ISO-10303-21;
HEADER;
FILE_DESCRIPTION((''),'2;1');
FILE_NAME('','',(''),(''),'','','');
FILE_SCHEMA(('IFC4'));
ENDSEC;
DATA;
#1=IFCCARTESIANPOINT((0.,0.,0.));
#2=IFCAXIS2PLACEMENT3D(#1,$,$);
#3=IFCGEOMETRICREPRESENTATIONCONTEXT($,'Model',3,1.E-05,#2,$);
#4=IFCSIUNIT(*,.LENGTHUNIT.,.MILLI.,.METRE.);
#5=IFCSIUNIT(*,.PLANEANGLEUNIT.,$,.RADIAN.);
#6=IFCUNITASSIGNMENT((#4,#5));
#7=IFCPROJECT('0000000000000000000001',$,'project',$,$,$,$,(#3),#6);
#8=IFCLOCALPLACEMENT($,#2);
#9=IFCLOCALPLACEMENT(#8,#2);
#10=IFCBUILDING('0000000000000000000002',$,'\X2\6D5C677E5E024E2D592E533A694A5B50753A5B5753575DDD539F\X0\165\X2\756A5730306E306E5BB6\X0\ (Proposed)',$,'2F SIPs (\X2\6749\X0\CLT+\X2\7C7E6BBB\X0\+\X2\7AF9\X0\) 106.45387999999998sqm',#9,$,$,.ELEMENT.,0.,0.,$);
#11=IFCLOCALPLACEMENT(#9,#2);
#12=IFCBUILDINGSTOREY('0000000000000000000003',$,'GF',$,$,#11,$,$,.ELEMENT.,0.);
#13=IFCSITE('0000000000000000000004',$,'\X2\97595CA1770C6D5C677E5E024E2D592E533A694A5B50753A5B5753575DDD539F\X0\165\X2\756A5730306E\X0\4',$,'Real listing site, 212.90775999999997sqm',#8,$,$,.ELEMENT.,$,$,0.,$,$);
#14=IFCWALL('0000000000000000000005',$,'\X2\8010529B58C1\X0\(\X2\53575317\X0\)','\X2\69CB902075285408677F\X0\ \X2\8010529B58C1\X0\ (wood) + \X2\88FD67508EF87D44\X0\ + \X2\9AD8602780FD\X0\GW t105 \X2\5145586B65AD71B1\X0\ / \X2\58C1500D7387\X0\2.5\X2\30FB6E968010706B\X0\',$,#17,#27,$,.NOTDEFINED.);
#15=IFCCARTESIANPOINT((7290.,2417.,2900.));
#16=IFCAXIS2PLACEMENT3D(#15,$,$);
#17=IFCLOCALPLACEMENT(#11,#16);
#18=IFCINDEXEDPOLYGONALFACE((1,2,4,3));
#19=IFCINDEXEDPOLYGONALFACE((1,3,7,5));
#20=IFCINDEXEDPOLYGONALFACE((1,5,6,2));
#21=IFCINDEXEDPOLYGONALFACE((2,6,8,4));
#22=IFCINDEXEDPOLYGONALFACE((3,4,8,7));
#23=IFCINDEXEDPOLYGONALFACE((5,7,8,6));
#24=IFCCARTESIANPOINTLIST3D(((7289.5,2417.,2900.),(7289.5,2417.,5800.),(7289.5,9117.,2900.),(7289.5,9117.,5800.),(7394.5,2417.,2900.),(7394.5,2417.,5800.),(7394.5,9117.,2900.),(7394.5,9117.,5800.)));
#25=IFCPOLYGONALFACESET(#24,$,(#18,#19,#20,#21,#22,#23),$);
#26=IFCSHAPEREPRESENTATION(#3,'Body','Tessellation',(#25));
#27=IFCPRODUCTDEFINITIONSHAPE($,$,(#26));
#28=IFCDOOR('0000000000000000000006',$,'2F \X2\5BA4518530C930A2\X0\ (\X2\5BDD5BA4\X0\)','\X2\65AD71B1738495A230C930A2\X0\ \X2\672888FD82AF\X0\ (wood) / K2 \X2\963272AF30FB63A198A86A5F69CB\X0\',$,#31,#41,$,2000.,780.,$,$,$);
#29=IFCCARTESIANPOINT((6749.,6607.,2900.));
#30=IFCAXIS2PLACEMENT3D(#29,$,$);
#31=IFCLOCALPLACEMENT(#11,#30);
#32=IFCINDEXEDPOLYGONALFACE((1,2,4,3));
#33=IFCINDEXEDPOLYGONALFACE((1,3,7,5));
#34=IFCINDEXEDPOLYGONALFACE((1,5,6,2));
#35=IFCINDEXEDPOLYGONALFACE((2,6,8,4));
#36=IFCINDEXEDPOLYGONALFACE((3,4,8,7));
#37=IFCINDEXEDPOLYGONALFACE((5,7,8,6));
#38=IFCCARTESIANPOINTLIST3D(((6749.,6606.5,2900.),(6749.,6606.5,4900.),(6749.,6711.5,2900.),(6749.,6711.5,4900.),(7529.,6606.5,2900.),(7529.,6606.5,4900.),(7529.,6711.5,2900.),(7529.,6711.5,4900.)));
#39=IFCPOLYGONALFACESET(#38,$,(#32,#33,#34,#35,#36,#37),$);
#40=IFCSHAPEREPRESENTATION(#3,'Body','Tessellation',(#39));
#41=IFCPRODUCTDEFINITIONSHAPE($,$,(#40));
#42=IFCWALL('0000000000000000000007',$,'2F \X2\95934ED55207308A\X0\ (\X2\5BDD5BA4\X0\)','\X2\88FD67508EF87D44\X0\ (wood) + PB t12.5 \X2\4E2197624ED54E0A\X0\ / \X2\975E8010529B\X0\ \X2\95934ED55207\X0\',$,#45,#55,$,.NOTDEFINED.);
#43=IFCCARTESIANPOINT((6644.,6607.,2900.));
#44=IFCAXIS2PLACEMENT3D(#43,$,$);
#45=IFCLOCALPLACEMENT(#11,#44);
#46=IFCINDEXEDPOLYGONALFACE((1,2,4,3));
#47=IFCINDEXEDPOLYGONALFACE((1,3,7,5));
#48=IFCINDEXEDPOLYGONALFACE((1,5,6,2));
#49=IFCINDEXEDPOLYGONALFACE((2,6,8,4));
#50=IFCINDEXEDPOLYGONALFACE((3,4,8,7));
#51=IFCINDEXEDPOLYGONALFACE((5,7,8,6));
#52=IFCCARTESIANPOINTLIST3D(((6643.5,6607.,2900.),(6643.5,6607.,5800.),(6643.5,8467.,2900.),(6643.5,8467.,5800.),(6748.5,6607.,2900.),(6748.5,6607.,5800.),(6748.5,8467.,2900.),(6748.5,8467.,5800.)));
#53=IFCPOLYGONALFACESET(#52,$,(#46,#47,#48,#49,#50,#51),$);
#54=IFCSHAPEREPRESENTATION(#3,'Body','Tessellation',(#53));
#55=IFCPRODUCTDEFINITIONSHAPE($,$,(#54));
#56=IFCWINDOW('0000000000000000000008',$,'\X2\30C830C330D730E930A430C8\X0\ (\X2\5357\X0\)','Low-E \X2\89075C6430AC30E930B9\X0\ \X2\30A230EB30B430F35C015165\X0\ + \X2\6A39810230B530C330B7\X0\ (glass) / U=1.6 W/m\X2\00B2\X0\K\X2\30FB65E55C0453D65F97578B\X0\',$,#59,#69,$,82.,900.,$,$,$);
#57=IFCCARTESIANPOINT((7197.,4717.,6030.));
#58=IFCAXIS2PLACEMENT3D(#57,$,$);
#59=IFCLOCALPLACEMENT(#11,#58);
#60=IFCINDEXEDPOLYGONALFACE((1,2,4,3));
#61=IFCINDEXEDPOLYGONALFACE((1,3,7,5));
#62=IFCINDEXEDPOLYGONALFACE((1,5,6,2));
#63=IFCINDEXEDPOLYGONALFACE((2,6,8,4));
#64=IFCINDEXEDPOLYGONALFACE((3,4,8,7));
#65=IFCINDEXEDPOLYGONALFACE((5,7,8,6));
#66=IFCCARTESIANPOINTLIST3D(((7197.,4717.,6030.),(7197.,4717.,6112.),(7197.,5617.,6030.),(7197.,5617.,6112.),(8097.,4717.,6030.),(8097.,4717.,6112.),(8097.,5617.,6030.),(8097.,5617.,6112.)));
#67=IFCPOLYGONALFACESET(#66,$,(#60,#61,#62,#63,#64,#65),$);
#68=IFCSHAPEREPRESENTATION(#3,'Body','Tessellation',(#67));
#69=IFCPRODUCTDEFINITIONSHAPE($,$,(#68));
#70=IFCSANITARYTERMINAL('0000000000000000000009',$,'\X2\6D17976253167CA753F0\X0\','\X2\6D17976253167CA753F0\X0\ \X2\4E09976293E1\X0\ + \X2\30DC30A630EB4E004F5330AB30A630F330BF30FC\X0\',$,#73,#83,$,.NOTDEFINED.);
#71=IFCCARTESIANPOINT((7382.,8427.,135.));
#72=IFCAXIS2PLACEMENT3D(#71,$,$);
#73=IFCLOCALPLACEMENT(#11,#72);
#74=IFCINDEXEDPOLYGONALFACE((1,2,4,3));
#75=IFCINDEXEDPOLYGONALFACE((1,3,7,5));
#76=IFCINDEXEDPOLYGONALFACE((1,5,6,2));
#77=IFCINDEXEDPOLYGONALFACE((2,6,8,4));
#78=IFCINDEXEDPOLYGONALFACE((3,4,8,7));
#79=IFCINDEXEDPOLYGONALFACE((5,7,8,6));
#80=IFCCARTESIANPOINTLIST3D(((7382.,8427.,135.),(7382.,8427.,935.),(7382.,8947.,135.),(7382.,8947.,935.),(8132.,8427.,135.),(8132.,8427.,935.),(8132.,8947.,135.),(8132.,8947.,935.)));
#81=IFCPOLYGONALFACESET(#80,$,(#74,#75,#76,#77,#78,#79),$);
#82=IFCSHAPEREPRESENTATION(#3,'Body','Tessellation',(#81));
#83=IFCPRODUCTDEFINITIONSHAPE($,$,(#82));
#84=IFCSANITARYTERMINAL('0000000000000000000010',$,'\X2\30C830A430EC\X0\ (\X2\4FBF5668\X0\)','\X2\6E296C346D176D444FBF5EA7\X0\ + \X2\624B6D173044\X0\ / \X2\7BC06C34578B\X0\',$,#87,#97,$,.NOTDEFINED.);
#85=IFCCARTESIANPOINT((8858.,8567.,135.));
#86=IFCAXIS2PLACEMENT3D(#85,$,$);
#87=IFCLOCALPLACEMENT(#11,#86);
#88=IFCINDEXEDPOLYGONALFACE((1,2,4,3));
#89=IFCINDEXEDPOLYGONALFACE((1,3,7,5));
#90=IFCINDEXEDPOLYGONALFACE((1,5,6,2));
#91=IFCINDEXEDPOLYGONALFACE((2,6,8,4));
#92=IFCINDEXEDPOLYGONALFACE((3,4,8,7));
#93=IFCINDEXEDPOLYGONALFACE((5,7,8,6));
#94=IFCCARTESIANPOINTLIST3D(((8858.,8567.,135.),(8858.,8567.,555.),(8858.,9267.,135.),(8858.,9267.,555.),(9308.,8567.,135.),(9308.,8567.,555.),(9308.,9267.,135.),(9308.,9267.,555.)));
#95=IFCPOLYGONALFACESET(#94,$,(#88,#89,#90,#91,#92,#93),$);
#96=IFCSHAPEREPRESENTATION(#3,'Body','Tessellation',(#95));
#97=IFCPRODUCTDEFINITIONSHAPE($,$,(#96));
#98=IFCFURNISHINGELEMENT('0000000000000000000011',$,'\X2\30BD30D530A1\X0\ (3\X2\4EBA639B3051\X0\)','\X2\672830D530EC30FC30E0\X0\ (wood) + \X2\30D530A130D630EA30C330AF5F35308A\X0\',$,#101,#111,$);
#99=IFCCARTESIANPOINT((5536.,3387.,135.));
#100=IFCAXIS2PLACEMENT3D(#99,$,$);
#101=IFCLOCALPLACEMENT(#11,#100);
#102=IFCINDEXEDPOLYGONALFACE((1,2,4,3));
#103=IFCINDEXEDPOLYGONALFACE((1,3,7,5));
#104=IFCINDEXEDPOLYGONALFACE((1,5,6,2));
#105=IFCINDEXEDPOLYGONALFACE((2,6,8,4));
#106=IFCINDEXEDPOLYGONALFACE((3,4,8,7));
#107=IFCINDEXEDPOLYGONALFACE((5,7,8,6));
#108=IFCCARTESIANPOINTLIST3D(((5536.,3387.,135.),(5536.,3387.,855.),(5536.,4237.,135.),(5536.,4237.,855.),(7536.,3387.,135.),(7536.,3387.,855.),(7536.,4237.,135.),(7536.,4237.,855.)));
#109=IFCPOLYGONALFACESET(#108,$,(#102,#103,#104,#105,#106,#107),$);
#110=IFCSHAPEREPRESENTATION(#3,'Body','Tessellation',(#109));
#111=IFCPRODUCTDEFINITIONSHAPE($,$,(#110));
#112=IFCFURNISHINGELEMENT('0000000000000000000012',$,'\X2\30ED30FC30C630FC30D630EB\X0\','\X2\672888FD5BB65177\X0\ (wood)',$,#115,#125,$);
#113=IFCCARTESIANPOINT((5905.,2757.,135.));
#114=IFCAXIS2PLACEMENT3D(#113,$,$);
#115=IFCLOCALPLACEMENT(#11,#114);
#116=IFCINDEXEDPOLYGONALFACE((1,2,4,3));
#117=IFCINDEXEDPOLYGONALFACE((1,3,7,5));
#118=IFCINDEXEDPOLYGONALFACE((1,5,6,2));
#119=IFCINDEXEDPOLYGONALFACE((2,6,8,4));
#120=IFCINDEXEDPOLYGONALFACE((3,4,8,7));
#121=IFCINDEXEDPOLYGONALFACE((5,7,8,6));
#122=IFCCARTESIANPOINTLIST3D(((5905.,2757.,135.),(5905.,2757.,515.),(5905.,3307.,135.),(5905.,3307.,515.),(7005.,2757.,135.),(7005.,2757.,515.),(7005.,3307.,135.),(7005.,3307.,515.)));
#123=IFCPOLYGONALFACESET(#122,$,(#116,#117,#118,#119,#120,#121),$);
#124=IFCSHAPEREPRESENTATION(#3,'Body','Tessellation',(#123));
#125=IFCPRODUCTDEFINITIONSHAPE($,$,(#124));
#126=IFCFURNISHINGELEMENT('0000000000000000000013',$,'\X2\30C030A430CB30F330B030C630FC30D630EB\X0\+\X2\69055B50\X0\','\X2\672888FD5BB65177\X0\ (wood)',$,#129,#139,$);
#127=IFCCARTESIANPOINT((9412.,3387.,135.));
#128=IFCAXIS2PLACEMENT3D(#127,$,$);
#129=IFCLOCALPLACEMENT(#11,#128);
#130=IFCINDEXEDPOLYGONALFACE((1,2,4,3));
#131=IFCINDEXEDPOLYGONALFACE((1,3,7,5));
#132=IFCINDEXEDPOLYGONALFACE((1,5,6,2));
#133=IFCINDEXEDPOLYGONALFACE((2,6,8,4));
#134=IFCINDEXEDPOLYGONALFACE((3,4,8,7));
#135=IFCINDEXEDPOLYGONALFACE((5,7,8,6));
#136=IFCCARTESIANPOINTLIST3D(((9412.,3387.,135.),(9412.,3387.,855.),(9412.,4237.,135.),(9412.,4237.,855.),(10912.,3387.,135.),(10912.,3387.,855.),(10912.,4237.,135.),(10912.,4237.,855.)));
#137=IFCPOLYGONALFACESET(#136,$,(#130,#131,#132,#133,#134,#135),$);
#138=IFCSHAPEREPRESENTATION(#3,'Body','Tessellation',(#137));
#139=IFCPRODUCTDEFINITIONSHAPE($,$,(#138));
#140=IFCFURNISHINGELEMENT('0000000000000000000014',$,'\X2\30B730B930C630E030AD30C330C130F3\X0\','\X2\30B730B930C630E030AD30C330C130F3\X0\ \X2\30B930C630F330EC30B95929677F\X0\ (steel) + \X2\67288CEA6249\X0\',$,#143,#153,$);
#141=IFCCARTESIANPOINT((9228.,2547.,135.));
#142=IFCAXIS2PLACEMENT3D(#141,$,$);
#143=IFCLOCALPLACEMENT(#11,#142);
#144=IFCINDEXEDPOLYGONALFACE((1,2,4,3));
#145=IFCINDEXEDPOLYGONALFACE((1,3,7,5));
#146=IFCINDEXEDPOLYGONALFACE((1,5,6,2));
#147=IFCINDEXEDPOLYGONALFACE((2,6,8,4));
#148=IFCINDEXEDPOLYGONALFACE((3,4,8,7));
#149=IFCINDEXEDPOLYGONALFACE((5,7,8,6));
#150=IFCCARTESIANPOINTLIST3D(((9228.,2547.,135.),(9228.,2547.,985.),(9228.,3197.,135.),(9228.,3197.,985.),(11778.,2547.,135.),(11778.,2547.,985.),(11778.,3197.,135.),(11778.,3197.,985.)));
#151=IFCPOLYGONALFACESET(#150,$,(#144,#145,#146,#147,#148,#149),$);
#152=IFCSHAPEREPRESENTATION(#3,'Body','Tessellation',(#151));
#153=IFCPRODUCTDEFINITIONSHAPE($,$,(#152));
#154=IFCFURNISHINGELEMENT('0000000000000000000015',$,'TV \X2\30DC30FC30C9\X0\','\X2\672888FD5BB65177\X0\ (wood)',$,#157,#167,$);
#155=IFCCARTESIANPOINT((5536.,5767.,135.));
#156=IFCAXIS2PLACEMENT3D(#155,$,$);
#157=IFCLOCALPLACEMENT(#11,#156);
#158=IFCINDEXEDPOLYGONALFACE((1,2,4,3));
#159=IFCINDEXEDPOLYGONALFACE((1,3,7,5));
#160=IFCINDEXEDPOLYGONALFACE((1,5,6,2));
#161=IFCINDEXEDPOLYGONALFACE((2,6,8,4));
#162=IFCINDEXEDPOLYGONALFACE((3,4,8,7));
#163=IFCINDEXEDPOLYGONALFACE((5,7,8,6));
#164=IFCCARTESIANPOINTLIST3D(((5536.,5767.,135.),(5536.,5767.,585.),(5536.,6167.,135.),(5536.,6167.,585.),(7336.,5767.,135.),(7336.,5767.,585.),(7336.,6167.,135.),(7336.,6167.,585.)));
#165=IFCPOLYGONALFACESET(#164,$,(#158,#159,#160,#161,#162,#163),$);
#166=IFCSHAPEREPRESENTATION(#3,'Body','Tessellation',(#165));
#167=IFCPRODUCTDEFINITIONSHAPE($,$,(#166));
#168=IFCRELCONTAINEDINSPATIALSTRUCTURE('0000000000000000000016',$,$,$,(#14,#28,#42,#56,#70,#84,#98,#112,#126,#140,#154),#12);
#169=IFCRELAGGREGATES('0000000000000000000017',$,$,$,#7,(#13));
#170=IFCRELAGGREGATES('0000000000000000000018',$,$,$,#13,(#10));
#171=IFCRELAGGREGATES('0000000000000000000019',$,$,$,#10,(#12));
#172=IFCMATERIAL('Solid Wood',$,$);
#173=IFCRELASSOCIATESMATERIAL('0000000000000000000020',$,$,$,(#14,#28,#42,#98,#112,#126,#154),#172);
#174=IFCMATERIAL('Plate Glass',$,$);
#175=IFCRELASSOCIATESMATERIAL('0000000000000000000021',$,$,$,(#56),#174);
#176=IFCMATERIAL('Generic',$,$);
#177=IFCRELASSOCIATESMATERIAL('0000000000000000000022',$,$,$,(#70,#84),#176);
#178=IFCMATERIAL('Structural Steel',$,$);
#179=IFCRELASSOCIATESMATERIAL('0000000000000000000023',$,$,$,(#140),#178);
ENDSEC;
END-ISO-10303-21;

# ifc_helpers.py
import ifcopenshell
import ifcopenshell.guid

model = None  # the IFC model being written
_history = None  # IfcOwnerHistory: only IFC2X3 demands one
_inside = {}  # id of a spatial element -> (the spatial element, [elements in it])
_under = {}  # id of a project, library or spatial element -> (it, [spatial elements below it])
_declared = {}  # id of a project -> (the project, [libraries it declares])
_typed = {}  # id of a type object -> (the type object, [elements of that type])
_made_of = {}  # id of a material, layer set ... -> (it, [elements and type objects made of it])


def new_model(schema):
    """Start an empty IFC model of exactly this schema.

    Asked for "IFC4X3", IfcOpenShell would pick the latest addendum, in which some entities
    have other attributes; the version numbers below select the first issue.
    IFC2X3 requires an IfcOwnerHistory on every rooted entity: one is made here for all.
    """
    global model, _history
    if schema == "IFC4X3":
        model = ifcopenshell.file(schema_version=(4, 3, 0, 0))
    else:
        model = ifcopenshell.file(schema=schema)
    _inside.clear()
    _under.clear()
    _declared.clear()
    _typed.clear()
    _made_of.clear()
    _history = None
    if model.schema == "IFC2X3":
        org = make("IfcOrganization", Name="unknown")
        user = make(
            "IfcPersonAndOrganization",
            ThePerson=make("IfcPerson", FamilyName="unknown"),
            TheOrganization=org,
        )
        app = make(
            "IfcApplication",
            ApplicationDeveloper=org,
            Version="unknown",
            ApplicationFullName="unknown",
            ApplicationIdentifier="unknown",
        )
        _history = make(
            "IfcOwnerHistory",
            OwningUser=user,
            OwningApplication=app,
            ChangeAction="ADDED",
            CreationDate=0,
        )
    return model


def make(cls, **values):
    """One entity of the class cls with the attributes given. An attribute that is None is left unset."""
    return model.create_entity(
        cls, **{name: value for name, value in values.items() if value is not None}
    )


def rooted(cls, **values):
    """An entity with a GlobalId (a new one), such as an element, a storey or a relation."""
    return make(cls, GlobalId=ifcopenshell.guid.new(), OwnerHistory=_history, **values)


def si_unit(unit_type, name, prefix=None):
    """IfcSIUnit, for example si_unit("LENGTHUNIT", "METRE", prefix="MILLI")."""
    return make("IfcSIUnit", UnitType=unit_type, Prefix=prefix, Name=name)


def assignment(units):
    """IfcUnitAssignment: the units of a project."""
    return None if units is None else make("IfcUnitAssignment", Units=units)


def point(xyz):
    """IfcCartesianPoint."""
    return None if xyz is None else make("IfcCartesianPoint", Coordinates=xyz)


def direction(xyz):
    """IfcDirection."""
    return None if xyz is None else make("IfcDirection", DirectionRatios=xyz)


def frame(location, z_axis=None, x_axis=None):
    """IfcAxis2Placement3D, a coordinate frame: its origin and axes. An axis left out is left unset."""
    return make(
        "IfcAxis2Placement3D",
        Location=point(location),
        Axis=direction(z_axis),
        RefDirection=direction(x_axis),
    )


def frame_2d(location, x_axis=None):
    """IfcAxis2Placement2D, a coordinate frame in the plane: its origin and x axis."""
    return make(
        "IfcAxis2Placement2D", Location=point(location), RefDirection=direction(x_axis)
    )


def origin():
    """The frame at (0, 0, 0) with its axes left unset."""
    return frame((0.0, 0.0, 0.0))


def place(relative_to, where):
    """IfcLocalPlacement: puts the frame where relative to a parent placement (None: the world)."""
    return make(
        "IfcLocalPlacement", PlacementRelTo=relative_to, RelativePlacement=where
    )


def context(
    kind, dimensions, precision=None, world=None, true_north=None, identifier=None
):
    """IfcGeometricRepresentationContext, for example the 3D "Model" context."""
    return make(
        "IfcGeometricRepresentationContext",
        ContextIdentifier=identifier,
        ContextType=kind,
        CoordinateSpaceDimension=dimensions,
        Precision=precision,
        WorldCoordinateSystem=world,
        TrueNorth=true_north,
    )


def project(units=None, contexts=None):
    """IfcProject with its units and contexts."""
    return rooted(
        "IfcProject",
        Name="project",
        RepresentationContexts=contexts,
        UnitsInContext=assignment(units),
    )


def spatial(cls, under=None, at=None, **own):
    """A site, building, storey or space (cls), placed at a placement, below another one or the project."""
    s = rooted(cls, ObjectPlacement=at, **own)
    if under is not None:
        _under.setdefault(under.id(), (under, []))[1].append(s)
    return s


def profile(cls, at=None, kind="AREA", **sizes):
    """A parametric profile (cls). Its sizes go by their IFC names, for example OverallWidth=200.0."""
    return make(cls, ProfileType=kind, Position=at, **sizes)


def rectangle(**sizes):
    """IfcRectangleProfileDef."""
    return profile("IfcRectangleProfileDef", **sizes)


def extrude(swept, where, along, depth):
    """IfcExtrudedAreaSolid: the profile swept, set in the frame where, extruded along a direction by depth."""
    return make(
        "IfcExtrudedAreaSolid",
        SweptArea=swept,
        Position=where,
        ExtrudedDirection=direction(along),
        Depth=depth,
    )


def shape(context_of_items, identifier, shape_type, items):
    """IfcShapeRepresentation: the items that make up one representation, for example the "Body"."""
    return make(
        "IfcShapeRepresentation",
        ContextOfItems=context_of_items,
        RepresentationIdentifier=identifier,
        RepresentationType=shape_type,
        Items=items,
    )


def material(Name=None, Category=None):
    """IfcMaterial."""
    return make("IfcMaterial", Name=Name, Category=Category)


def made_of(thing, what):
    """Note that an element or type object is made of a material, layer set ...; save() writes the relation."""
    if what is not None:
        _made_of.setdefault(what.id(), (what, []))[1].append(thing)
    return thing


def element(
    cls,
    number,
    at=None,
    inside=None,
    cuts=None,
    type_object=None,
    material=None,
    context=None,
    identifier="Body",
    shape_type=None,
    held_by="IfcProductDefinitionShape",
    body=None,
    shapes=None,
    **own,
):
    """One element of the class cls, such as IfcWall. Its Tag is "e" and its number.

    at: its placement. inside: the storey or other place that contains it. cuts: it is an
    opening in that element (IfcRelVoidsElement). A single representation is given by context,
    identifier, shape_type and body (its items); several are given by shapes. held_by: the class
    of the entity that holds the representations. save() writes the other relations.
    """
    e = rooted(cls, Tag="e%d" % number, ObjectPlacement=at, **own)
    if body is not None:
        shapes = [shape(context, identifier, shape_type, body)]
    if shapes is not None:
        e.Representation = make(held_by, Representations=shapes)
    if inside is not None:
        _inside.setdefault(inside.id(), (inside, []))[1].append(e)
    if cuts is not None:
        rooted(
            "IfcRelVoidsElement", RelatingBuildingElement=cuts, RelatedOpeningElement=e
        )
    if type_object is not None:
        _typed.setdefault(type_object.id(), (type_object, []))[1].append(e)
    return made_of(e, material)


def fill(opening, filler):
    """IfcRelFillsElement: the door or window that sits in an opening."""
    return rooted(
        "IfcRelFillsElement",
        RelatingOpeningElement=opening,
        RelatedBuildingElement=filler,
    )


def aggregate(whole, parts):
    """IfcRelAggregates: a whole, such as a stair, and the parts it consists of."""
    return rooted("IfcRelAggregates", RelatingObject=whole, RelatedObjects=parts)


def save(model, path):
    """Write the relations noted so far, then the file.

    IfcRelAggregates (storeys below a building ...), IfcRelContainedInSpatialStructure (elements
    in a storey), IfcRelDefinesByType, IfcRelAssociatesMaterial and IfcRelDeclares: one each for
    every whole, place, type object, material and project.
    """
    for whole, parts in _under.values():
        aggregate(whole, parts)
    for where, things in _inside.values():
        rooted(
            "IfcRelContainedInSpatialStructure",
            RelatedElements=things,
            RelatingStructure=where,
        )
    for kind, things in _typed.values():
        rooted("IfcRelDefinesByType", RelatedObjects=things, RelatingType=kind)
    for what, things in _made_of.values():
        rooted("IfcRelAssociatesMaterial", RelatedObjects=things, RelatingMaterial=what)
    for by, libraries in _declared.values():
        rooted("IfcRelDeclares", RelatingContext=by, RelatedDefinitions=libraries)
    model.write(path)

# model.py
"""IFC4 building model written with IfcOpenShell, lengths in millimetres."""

from ifc_helpers import new_model, si_unit, frame, frame_2d, origin, place, context, project, spatial, rectangle, extrude, material, element, fill, save


model = new_model("IFC4")

# Units and contexts
model_context = context("Model", 3, precision=1e-05, world=origin())
ifc_project = project(units=[si_unit("LENGTHUNIT", "METRE", prefix="MILLI"), si_unit("PLANEANGLEUNIT", "RADIAN")], contexts=[model_context])

# Site, building, storey
site_placement = place(None, origin())
site = spatial("IfcSite", under=ifc_project, at=site_placement, Name="静岡県浜松市中央区楊子町字南川原165番地の4", ObjectType="Real listing site, 212.90775999999997sqm", CompositionType="ELEMENT", RefElevation=0.0)
building_placement = place(site_placement, origin())
building = spatial("IfcBuilding", under=site, at=building_placement, Name="浜松市中央区楊子町字南川原165番地のの家 (Proposed)", ObjectType="2F SIPs (杉CLT+籾殻+竹) 106.45387999999998sqm", CompositionType="ELEMENT", ElevationOfRefHeight=0.0, ElevationOfTerrain=0.0)
storey_placement = place(building_placement, origin())
storey = spatial("IfcBuildingStorey", under=building, at=storey_placement, Name="GF", CompositionType="ELEMENT", Elevation=0.0)

# Shared definitions
ifc_material_1 = material(Name="Solid Wood")

# Wall, opening, door
wall_1_placement = place(storey_placement, frame((7290.0, 2417.0, 2900.0)))
wall_1 = element("IfcWall", 1, at=wall_1_placement, inside=storey, material=ifc_material_1, Name="耐力壁(南北)", Description="構造用合板 耐力壁 (wood) + 製材軸組 + 高性能GW t105 充填断熱 / 壁倍率2.5・準耐火", PredefinedType="NOTDEFINED", context=model_context, shape_type="SweptSolid", body=[
    extrude(rectangle(XDim=105.0, YDim=6700.0, at=frame_2d((52.0, 3350.0))), frame((7290.0, 2417.0, 2900.0)), (0.0, 0.0, 1.0), 2900.0),
])
opening_1_placement = place(storey_placement, frame((6749.0, 6607.0, 2900.0)))
opening_1 = element("IfcOpeningElement", 2, at=opening_1_placement, cuts=wall_1, PredefinedType="NOTDEFINED", context=model_context, shape_type="SweptSolid", body=[
    extrude(rectangle(XDim=780.0, YDim=105.0, at=frame_2d((390.0, 52.0))), frame((6749.0, 6607.0, 2900.0)), (0.0, 0.0, 1.0), 2000.0),
])
door_1_placement = place(storey_placement, frame((6749.0, 6607.0, 2900.0)))
door_1 = element("IfcDoor", 3, at=door_1_placement, inside=storey, material=ifc_material_1, Name="2F 室内ドア (寝室)", Description="断熱玄関ドア 木製芯 (wood) / K2 防犯・採風機構", OverallHeight=2000.0, OverallWidth=780.0, context=model_context, shape_type="SweptSolid", body=[
    extrude(rectangle(XDim=780.0, YDim=105.0, at=frame_2d((390.0, 52.0))), frame((6749.0, 6607.0, 2900.0)), (0.0, 0.0, 1.0), 2000.0),
])
fill(opening_1, door_1)

# Wall
wall_2_placement = place(storey_placement, frame((6644.0, 6607.0, 2900.0)))
element("IfcWall", 4, at=wall_2_placement, inside=storey, material=ifc_material_1, Name="2F 間仕切り (寝室)", Description="製材軸組 (wood) + PB t12.5 両面仕上 / 非耐力 間仕切", PredefinedType="NOTDEFINED", context=model_context, shape_type="SweptSolid", body=[
    extrude(rectangle(XDim=105.0, YDim=1860.0, at=frame_2d((52.0, 930.0))), frame((6644.0, 6607.0, 2900.0)), (0.0, 0.0, 1.0), 2900.0),
])

# Window
ifc_material_2 = material(Name="Plate Glass")
window_placement = place(storey_placement, frame((7197.0, 4717.0, 6030.0)))
element("IfcWindow", 5, at=window_placement, inside=storey, material=ifc_material_2, Name="トップライト (南)", Description="Low-E 複層ガラス アルゴン封入 + 樹脂サッシ (glass) / U=1.6 W/m²K・日射取得型", OverallHeight=82.0, OverallWidth=900.0, context=model_context, shape_type="SweptSolid", body=[
    extrude(rectangle(XDim=900.0, YDim=900.0, at=frame_2d((450.0, 450.0))), frame((7197.0, 4717.0, 6030.0)), (0.0, 0.0, 1.0), 82.0),
])

# Sanitary terminals
ifc_material_3 = material(Name="Generic")
sanitary_terminal_1_placement = place(storey_placement, frame((7382.0, 8427.0, 135.0)))
element("IfcSanitaryTerminal", 6, at=sanitary_terminal_1_placement, inside=storey, material=ifc_material_3, Name="洗面化粧台", Description="洗面化粧台 三面鏡 + ボウル一体カウンター", PredefinedType="NOTDEFINED", context=model_context, shape_type="SweptSolid", body=[
    extrude(rectangle(XDim=750.0, YDim=520.0, at=frame_2d((375.0, 260.0))), frame((7382.0, 8427.0, 135.0)), (0.0, 0.0, 1.0), 800.0),
])
sanitary_terminal_2_placement = place(storey_placement, frame((8858.0, 8567.0, 135.0)))
element("IfcSanitaryTerminal", 7, at=sanitary_terminal_2_placement, inside=storey, material=ifc_material_3, Name="トイレ (便器)", Description="温水洗浄便座 + 手洗い / 節水型", PredefinedType="NOTDEFINED", context=model_context, shape_type="SweptSolid", body=[
    extrude(rectangle(XDim=450.0, YDim=700.0, at=frame_2d((225.0, 350.0))), frame((8858.0, 8567.0, 135.0)), (0.0, 0.0, 1.0), 420.0),
])

# Furnishing elements
furnishing_1_placement = place(storey_placement, frame((5536.0, 3387.0, 135.0)))
element("IfcFurnishingElement", 8, at=furnishing_1_placement, inside=storey, material=ifc_material_1, Name="ソファ (3人掛け)", Description="木フレーム (wood) + ファブリック張り", context=model_context, shape_type="SweptSolid", body=[
    extrude(rectangle(XDim=2000.0, YDim=850.0, at=frame_2d((1000.0, 425.0))), frame((5536.0, 3387.0, 135.0)), (0.0, 0.0, 1.0), 720.0),
])
furnishing_2_placement = place(storey_placement, frame((5905.0, 2757.0, 135.0)))
element("IfcFurnishingElement", 9, at=furnishing_2_placement, inside=storey, material=ifc_material_1, Name="ローテーブル", Description="木製家具 (wood)", context=model_context, shape_type="SweptSolid", body=[
    extrude(rectangle(XDim=1100.0, YDim=550.0, at=frame_2d((550.0, 275.0))), frame((5905.0, 2757.0, 135.0)), (0.0, 0.0, 1.0), 380.0),
])
furnishing_3_placement = place(storey_placement, frame((9412.0, 3387.0, 135.0)))
element("IfcFurnishingElement", 10, at=furnishing_3_placement, inside=storey, material=ifc_material_1, Name="ダイニングテーブル+椅子", Description="木製家具 (wood)", context=model_context, shape_type="SweptSolid", body=[
    extrude(rectangle(XDim=1500.0, YDim=850.0, at=frame_2d((750.0, 425.0))), frame((9412.0, 3387.0, 135.0)), (0.0, 0.0, 1.0), 720.0),
])
ifc_material_4 = material(Name="Structural Steel")
furnishing_4_placement = place(storey_placement, frame((9228.0, 2547.0, 135.0)))
element("IfcFurnishingElement", 11, at=furnishing_4_placement, inside=storey, material=ifc_material_4, Name="システムキッチン", Description="システムキッチン ステンレス天板 (steel) + 木質扉", context=model_context, shape_type="SweptSolid", body=[
    extrude(rectangle(XDim=2550.0, YDim=650.0, at=frame_2d((1275.0, 325.0))), frame((9228.0, 2547.0, 135.0)), (0.0, 0.0, 1.0), 850.0),
])
furnishing_5_placement = place(storey_placement, frame((5536.0, 5767.0, 135.0)))
element("IfcFurnishingElement", 12, at=furnishing_5_placement, inside=storey, material=ifc_material_1, Name="TV ボード", Description="木製家具 (wood)", context=model_context, shape_type="SweptSolid", body=[
    extrude(rectangle(XDim=1800.0, YDim=400.0, at=frame_2d((900.0, 200.0))), frame((5536.0, 5767.0, 135.0)), (0.0, 0.0, 1.0), 450.0),
])

save(model, "model.ifc")
